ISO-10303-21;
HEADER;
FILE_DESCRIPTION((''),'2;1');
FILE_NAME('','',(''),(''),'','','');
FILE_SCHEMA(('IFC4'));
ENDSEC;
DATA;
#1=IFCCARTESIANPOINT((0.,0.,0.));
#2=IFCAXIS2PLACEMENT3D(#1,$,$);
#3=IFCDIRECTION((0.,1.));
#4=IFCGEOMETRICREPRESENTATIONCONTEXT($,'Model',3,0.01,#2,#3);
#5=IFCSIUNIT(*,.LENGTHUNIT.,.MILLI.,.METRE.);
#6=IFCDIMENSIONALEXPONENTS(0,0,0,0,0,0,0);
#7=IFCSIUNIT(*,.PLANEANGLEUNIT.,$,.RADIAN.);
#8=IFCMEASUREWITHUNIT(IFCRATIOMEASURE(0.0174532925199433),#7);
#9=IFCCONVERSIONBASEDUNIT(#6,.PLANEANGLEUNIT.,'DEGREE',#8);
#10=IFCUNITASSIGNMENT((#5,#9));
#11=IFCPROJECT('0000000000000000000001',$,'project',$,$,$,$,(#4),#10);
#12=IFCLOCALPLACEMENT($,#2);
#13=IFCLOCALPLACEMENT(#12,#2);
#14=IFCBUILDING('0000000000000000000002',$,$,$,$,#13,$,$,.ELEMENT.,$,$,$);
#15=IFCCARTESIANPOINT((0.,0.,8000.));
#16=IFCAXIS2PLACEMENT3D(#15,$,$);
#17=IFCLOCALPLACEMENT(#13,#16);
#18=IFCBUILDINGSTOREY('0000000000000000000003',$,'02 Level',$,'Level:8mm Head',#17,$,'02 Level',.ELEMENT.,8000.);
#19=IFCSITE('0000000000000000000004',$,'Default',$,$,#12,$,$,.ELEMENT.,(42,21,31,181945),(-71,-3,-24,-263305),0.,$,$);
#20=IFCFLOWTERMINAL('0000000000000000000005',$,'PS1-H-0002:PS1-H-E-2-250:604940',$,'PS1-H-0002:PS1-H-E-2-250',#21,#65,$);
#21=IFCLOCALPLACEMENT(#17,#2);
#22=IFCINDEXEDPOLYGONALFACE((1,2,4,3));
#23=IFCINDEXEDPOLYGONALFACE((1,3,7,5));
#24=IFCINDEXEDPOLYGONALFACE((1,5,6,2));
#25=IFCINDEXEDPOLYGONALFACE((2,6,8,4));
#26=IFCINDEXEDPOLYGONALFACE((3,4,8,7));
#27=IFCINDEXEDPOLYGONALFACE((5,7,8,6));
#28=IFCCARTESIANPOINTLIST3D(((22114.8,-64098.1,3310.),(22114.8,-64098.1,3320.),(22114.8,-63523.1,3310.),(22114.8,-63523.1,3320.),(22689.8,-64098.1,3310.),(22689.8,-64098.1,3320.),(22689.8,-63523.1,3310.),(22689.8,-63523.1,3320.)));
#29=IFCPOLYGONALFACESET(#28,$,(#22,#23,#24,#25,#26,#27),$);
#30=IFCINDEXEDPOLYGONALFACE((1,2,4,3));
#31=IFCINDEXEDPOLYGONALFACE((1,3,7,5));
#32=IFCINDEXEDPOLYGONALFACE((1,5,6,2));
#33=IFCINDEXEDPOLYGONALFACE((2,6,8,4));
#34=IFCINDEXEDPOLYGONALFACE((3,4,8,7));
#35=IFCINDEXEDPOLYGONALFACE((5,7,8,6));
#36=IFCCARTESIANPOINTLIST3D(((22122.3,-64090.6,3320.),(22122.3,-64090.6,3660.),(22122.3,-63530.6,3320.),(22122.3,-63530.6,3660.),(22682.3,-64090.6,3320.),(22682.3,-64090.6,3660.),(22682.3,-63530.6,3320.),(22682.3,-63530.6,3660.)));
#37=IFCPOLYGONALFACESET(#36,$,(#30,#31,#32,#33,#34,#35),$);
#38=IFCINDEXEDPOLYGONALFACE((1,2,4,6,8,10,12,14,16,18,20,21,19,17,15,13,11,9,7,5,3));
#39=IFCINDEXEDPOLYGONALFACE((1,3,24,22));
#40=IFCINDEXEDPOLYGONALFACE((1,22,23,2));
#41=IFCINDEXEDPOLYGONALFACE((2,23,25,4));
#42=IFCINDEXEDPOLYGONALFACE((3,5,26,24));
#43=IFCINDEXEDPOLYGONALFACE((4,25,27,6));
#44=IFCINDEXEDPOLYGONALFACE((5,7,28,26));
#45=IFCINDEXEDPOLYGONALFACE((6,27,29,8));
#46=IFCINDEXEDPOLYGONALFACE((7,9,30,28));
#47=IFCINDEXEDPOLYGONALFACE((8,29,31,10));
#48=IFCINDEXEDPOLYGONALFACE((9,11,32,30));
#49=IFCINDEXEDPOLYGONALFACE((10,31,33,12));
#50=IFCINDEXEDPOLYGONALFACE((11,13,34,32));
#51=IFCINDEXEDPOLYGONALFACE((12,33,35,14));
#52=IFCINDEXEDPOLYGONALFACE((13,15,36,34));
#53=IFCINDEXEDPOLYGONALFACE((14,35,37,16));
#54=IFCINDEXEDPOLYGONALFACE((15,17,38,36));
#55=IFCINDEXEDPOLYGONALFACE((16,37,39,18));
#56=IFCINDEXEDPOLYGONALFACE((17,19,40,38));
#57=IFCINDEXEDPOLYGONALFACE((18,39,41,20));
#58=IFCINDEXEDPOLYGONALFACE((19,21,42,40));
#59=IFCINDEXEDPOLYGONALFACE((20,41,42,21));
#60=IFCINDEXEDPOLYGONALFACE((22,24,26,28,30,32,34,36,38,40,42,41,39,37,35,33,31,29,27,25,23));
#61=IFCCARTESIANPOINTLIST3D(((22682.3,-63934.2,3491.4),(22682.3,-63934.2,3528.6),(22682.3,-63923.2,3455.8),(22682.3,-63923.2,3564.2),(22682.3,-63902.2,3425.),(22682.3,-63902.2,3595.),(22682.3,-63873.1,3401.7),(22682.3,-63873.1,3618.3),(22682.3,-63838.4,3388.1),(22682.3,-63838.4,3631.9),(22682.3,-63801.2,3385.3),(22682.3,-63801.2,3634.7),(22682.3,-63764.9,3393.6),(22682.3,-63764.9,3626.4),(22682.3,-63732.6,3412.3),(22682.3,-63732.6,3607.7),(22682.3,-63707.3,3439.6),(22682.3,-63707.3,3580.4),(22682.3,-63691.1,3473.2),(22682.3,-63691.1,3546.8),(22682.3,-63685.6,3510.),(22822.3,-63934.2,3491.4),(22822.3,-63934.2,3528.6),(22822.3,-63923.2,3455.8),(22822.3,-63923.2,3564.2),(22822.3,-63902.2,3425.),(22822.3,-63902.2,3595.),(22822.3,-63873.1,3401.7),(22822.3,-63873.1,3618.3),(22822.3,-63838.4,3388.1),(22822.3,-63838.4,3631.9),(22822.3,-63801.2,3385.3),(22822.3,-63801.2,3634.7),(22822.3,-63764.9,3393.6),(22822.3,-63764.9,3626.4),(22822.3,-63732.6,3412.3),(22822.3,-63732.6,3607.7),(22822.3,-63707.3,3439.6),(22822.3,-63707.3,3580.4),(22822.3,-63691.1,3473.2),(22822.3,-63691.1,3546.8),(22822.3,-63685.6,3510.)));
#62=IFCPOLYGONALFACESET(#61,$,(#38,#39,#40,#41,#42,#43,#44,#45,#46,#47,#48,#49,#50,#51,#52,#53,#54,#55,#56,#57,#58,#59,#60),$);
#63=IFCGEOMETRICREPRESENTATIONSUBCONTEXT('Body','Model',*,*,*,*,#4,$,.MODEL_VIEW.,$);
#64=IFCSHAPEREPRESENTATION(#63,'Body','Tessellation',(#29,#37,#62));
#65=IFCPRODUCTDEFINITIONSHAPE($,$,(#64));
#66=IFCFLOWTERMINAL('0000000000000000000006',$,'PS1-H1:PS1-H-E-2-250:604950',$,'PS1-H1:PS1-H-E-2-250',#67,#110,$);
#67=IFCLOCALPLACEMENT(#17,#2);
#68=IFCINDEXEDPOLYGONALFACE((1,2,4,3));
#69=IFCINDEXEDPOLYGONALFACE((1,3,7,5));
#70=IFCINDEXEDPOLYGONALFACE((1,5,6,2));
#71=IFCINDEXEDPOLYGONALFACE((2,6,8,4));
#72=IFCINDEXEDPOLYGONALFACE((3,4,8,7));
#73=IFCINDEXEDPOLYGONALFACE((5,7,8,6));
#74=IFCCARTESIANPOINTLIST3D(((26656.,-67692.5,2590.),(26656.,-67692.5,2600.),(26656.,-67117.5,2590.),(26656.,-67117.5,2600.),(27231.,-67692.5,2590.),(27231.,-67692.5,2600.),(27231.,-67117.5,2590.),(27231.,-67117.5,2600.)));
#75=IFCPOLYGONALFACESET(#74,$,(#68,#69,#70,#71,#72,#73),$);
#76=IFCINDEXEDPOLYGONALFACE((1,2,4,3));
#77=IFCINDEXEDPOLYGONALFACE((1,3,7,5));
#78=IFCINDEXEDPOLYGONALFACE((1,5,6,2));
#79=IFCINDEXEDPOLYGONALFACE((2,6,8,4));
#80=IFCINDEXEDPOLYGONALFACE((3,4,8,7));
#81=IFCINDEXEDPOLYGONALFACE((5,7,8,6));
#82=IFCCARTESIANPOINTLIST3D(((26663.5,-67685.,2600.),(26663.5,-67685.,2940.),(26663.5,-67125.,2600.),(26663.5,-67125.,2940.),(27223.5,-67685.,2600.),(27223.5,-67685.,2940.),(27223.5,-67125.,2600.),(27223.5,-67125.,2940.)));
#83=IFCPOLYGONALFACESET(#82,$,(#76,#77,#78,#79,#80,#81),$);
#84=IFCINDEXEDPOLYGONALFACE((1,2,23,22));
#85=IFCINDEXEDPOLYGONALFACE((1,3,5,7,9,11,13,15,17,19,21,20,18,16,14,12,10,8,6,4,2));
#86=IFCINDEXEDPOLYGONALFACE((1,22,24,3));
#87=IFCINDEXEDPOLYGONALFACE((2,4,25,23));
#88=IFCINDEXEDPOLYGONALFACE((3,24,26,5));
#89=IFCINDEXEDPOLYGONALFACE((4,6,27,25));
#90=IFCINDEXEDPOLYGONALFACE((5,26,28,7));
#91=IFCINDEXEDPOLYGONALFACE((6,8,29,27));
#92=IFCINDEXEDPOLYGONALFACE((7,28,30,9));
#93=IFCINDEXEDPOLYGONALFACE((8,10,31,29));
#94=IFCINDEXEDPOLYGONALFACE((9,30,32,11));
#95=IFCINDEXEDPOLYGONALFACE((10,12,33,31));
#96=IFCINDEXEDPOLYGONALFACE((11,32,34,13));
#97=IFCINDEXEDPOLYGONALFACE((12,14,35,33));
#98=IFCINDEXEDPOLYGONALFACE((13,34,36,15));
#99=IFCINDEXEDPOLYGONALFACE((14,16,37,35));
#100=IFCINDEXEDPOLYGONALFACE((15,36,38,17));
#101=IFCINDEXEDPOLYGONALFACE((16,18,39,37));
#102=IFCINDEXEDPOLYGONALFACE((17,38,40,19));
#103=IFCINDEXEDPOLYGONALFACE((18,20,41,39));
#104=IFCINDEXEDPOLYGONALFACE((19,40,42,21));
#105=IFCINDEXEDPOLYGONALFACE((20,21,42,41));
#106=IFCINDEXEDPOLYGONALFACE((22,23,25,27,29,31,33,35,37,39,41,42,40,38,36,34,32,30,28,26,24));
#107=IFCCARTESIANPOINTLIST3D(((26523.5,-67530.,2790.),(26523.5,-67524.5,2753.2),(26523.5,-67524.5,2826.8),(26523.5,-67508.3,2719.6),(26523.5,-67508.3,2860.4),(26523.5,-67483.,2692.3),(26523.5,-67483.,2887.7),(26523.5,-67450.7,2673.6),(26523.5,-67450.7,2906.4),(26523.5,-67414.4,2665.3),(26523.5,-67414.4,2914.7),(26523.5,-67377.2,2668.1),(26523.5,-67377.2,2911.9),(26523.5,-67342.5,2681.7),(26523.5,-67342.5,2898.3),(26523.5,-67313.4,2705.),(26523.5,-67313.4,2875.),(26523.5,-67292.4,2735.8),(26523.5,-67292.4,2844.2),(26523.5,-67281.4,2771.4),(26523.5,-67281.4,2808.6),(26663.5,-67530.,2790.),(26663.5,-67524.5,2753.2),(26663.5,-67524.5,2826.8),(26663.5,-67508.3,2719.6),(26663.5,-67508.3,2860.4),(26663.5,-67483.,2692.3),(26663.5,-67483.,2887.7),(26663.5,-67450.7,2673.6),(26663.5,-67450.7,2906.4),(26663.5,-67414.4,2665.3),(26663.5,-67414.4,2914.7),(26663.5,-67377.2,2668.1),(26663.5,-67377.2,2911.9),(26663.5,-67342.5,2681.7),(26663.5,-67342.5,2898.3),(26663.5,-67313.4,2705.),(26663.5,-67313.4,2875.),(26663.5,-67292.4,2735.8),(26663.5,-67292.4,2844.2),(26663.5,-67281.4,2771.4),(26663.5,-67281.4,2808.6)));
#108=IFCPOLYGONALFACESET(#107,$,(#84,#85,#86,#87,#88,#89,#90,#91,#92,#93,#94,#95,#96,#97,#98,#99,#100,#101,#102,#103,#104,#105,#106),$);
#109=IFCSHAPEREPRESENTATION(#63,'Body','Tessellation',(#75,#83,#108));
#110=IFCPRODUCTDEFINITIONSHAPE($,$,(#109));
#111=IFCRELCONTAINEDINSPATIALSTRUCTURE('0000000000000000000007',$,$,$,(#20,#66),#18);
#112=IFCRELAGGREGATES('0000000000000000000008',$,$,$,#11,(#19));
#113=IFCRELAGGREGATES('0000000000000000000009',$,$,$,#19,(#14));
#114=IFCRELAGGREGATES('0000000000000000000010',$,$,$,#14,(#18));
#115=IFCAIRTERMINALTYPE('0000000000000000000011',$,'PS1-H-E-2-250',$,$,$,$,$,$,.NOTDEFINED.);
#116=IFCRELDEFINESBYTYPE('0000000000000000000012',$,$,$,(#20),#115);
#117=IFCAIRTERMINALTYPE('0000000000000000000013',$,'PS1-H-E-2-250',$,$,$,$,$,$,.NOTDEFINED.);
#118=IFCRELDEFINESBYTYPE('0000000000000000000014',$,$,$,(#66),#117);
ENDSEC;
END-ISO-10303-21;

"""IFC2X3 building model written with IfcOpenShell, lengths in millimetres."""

from ifc_helpers import new_model, entity, si_unit, converted_unit, direction, frame, frame_2d, origin, origin_2d_with_axis, place, context, subcontext, project, spatial, rectangle, circle, extrude, source, transform, mapped, type_object, type_shapes, element, save


model = new_model("IFC2X3")

# Units and contexts
model_context = context("Model", 3, precision=0.01, world=origin(), true_north=direction((0.0, 1.0)))
body_context = subcontext(model_context, "Body", "Model", "MODEL_VIEW")
ifc_project = project(units=[si_unit("LENGTHUNIT", "METRE", prefix="MILLI"), converted_unit("PLANEANGLEUNIT", "DEGREE", entity("IfcRatioMeasure", 0.0174532925199433), si_unit("PLANEANGLEUNIT", "RADIAN"), dimensions=[0, 0, 0, 0, 0, 0, 0])], contexts=[model_context])

# Site, building, storey
site_placement = place(None, origin())
site = spatial("IfcSite", under=ifc_project, at=site_placement, Name="Default", CompositionType="ELEMENT", RefLatitude=(42, 21, 31, 181945), RefLongitude=(-71, -3, -24, -263305), RefElevation=0.0)
building_placement = place(site_placement, origin())
building = spatial("IfcBuilding", under=site, at=building_placement, CompositionType="ELEMENT")
storey_placement = place(building_placement, frame((0.0, 0.0, 8000.0)))
storey = spatial("IfcBuildingStorey", under=building, at=storey_placement, Name="02 Level", ObjectType="Level:8mm Head", LongName="02 Level", CompositionType="ELEMENT", Elevation=8000.0)

# Flow terminals
air_terminal_type_1 = type_object("IfcAirTerminalType", Name="PS1-H-E-2-250", PredefinedType="NOTDEFINED")
shared_shape_1 = source(origin(), body_context, "Body", "SweptSolid", [
    extrude(rectangle(XDim=575.0, YDim=575.0, at=origin_2d_with_axis()), frame((0.0, 0.0, -10.0), z_axis=(0.0, 0.0, 1.0), x_axis=(0.0, 1.0, 0.0)), (0.0, 0.0, 1.0), 10.0),
    extrude(rectangle(XDim=560.0, YDim=560.0, at=origin_2d_with_axis()), frame((0.0, 0.0, 0.0), z_axis=(0.0, 0.0, 1.0), x_axis=(0.0, 1.0, 0.0)), (0.0, 0.0, 1.0), 340.0),
    extrude(circle(Radius=125.0, at=frame_2d((0.0, 0.0), x_axis=(1.0, 0.0))), frame((-420.0, 0.0, 190.0), z_axis=(1.0, 0.0, 0.0), x_axis=(0.0, -1.0, 0.0)), (0.0, 0.0, 1.0), 140.0),
])
type_shapes(air_terminal_type_1, [shared_shape_1])
flow_terminal_1_placement = place(storey_placement, frame((22402.3, -63810.6, 3320.0), z_axis=(0.0, 0.0, 1.0), x_axis=(-1.0, 0.0, 0.0)))
element("IfcFlowTerminal", 1, at=flow_terminal_1_placement, inside=storey, type_object=air_terminal_type_1, Name="PS1-H-0002:PS1-H-E-2-250:604940", ObjectType="PS1-H-0002:PS1-H-E-2-250", context=body_context, shape_type="MappedRepresentation", body=[
    mapped(shared_shape_1, transform((0.0, 0.0, 0.0), scale=1.0)),
])
air_terminal_type_2 = type_object("IfcAirTerminalType", Name="PS1-H-E-2-250", PredefinedType="NOTDEFINED")
shared_shape_2 = source(origin(), body_context, "Body", "SweptSolid", [
    extrude(rectangle(XDim=575.0, YDim=575.0, at=origin_2d_with_axis()), frame((0.0, 0.0, -10.0), z_axis=(0.0, 0.0, 1.0), x_axis=(0.0, 1.0, 0.0)), (0.0, 0.0, 1.0), 10.0),
    extrude(rectangle(XDim=560.0, YDim=560.0, at=origin_2d_with_axis()), frame((0.0, 0.0, 0.0), z_axis=(0.0, 0.0, 1.0), x_axis=(0.0, 1.0, 0.0)), (0.0, 0.0, 1.0), 340.0),
    extrude(circle(Radius=125.0, at=frame_2d((0.0, 0.0), x_axis=(1.0, 0.0))), frame((-420.0, 0.0, 190.0), z_axis=(1.0, 0.0, 0.0), x_axis=(0.0, -1.0, 0.0)), (0.0, 0.0, 1.0), 140.0),
])
type_shapes(air_terminal_type_2, [shared_shape_2])
flow_terminal_2_placement = place(storey_placement, frame((26943.5, -67405.0, 2600.0)))
element("IfcFlowTerminal", 2, at=flow_terminal_2_placement, inside=storey, type_object=air_terminal_type_2, Name="PS1-H1:PS1-H-E-2-250:604950", ObjectType="PS1-H1:PS1-H-E-2-250", context=body_context, shape_type="MappedRepresentation", body=[
    mapped(shared_shape_2, transform((0.0, 0.0, 0.0), scale=1.0)),
])

save(model, "model.ifc")
